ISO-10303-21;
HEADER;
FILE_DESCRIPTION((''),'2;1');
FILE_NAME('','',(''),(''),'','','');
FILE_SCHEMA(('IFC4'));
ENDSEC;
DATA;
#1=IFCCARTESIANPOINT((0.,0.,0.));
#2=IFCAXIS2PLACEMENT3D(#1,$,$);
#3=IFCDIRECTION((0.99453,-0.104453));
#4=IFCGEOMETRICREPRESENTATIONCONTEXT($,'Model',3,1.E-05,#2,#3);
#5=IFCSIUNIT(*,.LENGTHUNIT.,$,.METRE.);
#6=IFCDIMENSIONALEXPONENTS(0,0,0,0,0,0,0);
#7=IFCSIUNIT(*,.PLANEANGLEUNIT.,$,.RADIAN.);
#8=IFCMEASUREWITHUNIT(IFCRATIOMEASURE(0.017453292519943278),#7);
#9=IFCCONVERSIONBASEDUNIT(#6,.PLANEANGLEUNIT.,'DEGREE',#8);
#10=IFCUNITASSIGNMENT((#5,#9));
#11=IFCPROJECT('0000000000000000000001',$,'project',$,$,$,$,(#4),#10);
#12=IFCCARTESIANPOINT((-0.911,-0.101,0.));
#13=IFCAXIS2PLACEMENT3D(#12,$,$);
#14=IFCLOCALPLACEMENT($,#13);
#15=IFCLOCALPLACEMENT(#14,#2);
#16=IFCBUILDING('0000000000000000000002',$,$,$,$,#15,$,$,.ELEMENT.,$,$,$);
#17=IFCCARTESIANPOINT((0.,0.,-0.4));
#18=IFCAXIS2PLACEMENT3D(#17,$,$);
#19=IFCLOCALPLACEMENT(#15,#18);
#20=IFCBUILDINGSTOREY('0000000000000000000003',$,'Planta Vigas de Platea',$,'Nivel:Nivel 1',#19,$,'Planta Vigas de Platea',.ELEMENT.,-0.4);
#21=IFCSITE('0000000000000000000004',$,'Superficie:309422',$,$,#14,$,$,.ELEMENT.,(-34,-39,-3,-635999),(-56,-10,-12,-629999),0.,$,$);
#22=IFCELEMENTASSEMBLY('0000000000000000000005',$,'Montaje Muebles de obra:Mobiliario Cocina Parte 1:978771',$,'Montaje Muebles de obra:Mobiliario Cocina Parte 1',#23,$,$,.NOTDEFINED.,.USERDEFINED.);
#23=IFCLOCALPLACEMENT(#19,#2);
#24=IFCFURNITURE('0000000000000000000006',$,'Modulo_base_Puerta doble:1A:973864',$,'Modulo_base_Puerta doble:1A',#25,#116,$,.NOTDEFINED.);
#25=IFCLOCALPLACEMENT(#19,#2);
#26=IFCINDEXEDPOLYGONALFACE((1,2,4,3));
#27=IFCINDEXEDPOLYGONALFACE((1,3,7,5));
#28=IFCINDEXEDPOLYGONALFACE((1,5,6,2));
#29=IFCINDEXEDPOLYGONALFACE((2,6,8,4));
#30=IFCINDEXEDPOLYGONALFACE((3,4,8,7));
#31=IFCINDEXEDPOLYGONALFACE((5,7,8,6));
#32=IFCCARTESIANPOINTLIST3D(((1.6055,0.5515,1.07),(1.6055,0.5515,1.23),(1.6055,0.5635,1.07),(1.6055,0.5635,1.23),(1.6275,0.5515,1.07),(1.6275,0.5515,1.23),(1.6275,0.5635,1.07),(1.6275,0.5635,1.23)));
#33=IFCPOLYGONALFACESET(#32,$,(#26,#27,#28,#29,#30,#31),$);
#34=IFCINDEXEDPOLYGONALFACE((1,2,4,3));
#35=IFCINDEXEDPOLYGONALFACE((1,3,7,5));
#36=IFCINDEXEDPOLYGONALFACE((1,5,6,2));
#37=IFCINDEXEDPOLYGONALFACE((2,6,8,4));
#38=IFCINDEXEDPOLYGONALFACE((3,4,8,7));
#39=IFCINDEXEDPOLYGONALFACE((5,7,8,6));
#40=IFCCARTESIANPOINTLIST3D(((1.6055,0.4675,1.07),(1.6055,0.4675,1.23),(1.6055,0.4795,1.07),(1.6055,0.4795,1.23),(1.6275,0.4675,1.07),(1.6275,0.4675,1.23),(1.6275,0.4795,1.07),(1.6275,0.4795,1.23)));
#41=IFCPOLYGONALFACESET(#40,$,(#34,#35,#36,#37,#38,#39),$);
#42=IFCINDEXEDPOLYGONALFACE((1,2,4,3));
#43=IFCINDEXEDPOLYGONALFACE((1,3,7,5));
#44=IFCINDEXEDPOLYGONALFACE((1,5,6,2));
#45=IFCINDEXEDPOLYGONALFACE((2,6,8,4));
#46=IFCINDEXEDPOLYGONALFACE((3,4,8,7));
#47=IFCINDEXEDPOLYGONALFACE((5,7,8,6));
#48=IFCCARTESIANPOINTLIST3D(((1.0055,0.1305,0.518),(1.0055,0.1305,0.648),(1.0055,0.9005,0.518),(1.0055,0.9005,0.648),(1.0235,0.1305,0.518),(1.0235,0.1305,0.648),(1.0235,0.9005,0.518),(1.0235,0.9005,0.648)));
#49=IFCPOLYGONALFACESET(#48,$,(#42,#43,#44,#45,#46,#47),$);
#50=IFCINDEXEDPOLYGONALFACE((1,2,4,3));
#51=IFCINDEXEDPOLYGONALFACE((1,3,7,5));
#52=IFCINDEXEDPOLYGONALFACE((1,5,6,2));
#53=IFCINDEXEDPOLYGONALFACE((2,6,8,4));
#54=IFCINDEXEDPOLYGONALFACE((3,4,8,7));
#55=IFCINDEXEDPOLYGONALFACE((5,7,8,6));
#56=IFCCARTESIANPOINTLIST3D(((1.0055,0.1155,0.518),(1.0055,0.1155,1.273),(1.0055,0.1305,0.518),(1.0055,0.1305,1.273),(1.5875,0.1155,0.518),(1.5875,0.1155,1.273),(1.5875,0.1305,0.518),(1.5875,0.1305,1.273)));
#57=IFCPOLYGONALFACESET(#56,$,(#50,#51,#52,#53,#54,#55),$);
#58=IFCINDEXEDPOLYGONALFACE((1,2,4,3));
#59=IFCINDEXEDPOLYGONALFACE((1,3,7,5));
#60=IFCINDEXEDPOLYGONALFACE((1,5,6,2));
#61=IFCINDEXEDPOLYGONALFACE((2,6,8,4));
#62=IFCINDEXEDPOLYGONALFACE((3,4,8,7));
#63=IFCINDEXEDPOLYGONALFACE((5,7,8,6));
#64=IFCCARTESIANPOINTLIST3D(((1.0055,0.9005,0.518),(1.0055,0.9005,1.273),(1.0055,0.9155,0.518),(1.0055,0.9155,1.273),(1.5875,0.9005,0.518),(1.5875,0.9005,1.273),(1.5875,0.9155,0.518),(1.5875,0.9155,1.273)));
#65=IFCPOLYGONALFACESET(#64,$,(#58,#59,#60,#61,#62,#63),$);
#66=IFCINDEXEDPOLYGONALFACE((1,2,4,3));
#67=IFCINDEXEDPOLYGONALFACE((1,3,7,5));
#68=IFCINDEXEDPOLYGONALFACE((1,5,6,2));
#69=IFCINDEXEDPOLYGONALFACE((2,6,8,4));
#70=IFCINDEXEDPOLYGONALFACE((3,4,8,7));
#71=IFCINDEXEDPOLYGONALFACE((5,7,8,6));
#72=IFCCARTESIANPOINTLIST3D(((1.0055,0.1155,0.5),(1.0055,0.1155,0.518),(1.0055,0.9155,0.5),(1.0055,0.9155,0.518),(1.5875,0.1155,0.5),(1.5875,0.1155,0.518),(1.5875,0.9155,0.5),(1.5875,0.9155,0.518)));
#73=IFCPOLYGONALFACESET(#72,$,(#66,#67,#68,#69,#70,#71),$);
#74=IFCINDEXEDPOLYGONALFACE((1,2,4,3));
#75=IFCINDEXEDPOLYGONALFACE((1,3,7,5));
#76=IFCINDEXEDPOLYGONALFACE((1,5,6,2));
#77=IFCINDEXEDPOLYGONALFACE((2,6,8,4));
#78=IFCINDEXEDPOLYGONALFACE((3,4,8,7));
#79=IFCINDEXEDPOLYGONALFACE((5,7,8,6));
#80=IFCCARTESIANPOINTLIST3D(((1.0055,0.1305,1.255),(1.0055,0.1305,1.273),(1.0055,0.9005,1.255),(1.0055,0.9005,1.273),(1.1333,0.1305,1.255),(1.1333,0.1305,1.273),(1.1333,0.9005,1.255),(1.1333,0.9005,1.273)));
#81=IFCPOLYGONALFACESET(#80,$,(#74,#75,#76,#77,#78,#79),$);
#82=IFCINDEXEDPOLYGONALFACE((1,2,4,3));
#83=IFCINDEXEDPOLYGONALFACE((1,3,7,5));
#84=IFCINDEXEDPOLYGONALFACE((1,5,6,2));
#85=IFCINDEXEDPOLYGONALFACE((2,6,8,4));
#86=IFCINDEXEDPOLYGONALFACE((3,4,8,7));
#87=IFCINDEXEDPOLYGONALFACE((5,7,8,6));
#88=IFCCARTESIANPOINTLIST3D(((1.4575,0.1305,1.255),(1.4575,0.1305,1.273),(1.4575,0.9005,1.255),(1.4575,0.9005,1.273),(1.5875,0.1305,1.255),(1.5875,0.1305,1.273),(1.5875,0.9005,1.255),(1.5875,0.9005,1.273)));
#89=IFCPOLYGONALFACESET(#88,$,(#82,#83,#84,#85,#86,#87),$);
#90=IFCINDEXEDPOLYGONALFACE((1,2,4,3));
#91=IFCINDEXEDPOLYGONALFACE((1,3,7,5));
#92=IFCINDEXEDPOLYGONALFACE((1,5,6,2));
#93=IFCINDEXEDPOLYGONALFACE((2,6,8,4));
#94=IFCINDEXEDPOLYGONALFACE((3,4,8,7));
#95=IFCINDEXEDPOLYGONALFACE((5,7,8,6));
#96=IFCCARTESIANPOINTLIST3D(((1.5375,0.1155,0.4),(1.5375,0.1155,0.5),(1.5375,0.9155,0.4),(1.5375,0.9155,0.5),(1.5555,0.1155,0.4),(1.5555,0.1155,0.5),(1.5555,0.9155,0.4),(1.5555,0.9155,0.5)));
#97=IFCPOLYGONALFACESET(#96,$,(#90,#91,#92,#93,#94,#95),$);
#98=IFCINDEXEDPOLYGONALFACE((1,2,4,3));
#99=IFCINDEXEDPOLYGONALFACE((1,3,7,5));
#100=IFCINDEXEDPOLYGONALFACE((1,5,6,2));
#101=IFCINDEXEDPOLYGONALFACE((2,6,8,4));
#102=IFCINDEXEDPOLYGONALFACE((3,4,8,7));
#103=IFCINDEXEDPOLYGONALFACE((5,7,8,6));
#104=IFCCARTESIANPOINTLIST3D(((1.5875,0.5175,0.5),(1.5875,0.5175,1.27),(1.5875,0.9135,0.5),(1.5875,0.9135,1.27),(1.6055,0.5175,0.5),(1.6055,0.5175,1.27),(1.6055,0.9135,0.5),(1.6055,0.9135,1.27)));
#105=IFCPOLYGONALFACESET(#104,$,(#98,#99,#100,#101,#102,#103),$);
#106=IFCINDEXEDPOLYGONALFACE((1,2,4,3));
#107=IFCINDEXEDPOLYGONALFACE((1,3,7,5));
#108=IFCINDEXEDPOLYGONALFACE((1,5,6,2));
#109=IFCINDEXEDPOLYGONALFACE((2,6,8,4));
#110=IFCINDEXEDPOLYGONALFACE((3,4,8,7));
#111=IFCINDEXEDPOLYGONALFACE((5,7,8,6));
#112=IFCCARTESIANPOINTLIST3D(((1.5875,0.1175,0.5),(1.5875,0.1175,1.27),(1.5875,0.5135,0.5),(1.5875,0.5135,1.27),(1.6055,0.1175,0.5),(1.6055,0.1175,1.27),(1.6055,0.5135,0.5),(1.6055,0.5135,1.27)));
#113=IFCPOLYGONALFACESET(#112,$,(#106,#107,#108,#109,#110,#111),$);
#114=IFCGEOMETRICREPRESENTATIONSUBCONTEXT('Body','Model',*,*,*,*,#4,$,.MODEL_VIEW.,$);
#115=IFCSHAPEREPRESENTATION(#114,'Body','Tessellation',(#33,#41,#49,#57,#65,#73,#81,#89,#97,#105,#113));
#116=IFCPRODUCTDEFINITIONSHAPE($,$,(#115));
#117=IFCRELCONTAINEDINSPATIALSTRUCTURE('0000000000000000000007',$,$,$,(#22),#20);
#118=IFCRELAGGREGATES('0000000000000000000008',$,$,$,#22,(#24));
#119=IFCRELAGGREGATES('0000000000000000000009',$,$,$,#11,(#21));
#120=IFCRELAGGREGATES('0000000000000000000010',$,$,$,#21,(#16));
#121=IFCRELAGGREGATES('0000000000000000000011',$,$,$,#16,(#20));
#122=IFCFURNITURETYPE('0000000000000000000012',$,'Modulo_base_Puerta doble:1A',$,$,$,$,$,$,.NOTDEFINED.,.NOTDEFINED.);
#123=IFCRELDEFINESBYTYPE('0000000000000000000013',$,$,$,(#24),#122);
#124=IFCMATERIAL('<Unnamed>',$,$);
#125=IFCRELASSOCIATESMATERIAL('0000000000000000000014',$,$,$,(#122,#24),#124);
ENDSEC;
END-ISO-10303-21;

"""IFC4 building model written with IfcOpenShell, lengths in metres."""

from ifc_helpers import new_model, entity, si_unit, converted_unit, direction, frame, frame_2d, origin, origin_2d_with_axis, place, context, subcontext, project, spatial, rectangle, extrude, source, transform, mapped, material, type_object, type_shapes, element, aggregate, save


model = new_model("IFC4")

# Units and contexts
model_context = context("Model", 3, precision=1e-05, world=origin(), true_north=direction((0.99453, -0.104453)))
body_context = subcontext(model_context, "Body", "Model", "MODEL_VIEW")
ifc_project = project(units=[si_unit("LENGTHUNIT", "METRE"), converted_unit("PLANEANGLEUNIT", "DEGREE", entity("IfcRatioMeasure", 0.017453292519943278), si_unit("PLANEANGLEUNIT", "RADIAN"), dimensions=[0, 0, 0, 0, 0, 0, 0])], contexts=[model_context])

# Site, building, storey
site_placement = place(None, frame((-0.911, -0.101, 0.0)))
site = spatial("IfcSite", under=ifc_project, at=site_placement, Name="Superficie:309422", CompositionType="ELEMENT", RefLatitude=(-34, -39, -3, -635999), RefLongitude=(-56, -10, -12, -629999), RefElevation=0.0)
building_placement = place(site_placement, origin())
building = spatial("IfcBuilding", under=site, at=building_placement, CompositionType="ELEMENT")
storey_placement = place(building_placement, frame((0.0, 0.0, -0.4)))
storey = spatial("IfcBuildingStorey", under=building, at=storey_placement, Name="Planta Vigas de Platea", ObjectType="Nivel:Nivel 1", LongName="Planta Vigas de Platea", CompositionType="ELEMENT", Elevation=-0.4)

# Shared definitions
ifc_material_1 = material(Name="<Unnamed>")

# Element assembly, furniture
assembly_placement = place(storey_placement, origin())
assembly = element("IfcElementAssembly", 1, at=assembly_placement, inside=storey, Name="Montaje Muebles de obra:Mobiliario Cocina Parte 1:978771", ObjectType="Montaje Muebles de obra:Mobiliario Cocina Parte 1", AssemblyPlace="NOTDEFINED", PredefinedType="USERDEFINED")
furniture_type_1 = type_object("IfcFurnitureType", Name="Modulo_base_Puerta doble:1A", AssemblyPlace="NOTDEFINED", PredefinedType="NOTDEFINED", material=ifc_material_1)
shared_shape_1 = source(origin(), body_context, "Body", "SweptSolid", [
    extrude(rectangle(XDim=0.022, YDim=0.012, at=origin_2d_with_axis()), frame((0.611, 0.442, 0.67), z_axis=(0.0, 0.0, 1.0), x_axis=(-1.0, 0.0, 0.0)), (0.0, 0.0, 1.0), 0.16),
    extrude(rectangle(XDim=0.022, YDim=0.012, at=origin_2d_with_axis()), frame((0.611, 0.358, 0.67), z_axis=(0.0, 0.0, 1.0), x_axis=(-1.0, 0.0, 0.0)), (0.0, 0.0, 1.0), 0.16),
    extrude(rectangle(XDim=0.77, YDim=0.018, at=frame_2d((0.0, 0.0), x_axis=(1.0, 0.0))), frame((0.009, 0.4, 0.118), z_axis=(0.0, 0.0, 1.0), x_axis=(0.0, -1.0, 0.0)), (0.0, 0.0, 1.0), 0.13),
    extrude(rectangle(XDim=0.015, YDim=0.582, at=frame_2d((-0.0015, -0.0322), x_axis=(1.0, 0.0))), frame((0.3232, 0.006, 0.118), z_axis=(0.0, 0.0, 1.0), x_axis=(0.0, -1.0, 0.0)), (0.0, 0.0, 1.0), 0.755),
    extrude(rectangle(XDim=0.015, YDim=0.582, at=frame_2d((0.0, 0.0), x_axis=(1.0, 0.0))), frame((0.291, 0.7925, 0.118), z_axis=(0.0, 0.0, 1.0), x_axis=(0.0, 1.0, 0.0)), (0.0, 0.0, 1.0), 0.755),
    extrude(rectangle(XDim=0.8, YDim=0.582, at=frame_2d((-0.08, -0.0322), x_axis=(1.0, 0.0))), frame((0.3232, 0.32, 0.1), z_axis=(0.0, 0.0, 1.0), x_axis=(0.0, -1.0, 0.0)), (0.0, 0.0, 1.0), 0.018),
    extrude(rectangle(XDim=0.77, YDim=0.1278, at=frame_2d((0.0, 0.0), x_axis=(1.0, 0.0))), frame((0.0639, 0.4, 0.855), z_axis=(0.0, 0.0, 1.0), x_axis=(0.0, -1.0, 0.0)), (0.0, 0.0, 1.0), 0.018),
    extrude(rectangle(XDim=0.77, YDim=0.13, at=origin_2d_with_axis()), frame((0.517, 0.4, 0.855), z_axis=(0.0, 0.0, 1.0), x_axis=(0.0, -1.0, 0.0)), (0.0, 0.0, 1.0), 0.018),
    extrude(rectangle(XDim=0.018, YDim=0.8, at=frame_2d((0.0, 0.0), x_axis=(1.0, 0.0))), frame((0.541, 0.4, 0.0)), (0.0, 0.0, 1.0), 0.1),
    extrude(rectangle(XDim=0.018, YDim=0.396, at=frame_2d((0.0, 0.0), x_axis=(1.0, 0.0))), frame((0.591, 0.6, 0.1), z_axis=(0.0, 0.0, 1.0), x_axis=(-1.0, 0.0, 0.0)), (0.0, 0.0, 1.0), 0.77),
    extrude(rectangle(XDim=0.018, YDim=0.396, at=frame_2d((0.0, 0.0), x_axis=(1.0, 0.0))), frame((0.591, 0.2, 0.1), z_axis=(0.0, 0.0, 1.0), x_axis=(-1.0, 0.0, 0.0)), (0.0, 0.0, 1.0), 0.77),
])
type_shapes(furniture_type_1, [shared_shape_1])
furniture_1_placement = place(assembly_placement, frame((1.0055, 0.1155, 0.4)))
furniture_1 = element("IfcFurniture", 2, at=furniture_1_placement, type_object=furniture_type_1, material=ifc_material_1, Name="Modulo_base_Puerta doble:1A:973864", ObjectType="Modulo_base_Puerta doble:1A", PredefinedType="NOTDEFINED", context=body_context, shape_type="MappedRepresentation", body=[
    mapped(shared_shape_1, transform((0.0, 0.0, 0.0), scale=1.0)),
])
aggregate(assembly, [furniture_1])

save(model, "model.ifc")
